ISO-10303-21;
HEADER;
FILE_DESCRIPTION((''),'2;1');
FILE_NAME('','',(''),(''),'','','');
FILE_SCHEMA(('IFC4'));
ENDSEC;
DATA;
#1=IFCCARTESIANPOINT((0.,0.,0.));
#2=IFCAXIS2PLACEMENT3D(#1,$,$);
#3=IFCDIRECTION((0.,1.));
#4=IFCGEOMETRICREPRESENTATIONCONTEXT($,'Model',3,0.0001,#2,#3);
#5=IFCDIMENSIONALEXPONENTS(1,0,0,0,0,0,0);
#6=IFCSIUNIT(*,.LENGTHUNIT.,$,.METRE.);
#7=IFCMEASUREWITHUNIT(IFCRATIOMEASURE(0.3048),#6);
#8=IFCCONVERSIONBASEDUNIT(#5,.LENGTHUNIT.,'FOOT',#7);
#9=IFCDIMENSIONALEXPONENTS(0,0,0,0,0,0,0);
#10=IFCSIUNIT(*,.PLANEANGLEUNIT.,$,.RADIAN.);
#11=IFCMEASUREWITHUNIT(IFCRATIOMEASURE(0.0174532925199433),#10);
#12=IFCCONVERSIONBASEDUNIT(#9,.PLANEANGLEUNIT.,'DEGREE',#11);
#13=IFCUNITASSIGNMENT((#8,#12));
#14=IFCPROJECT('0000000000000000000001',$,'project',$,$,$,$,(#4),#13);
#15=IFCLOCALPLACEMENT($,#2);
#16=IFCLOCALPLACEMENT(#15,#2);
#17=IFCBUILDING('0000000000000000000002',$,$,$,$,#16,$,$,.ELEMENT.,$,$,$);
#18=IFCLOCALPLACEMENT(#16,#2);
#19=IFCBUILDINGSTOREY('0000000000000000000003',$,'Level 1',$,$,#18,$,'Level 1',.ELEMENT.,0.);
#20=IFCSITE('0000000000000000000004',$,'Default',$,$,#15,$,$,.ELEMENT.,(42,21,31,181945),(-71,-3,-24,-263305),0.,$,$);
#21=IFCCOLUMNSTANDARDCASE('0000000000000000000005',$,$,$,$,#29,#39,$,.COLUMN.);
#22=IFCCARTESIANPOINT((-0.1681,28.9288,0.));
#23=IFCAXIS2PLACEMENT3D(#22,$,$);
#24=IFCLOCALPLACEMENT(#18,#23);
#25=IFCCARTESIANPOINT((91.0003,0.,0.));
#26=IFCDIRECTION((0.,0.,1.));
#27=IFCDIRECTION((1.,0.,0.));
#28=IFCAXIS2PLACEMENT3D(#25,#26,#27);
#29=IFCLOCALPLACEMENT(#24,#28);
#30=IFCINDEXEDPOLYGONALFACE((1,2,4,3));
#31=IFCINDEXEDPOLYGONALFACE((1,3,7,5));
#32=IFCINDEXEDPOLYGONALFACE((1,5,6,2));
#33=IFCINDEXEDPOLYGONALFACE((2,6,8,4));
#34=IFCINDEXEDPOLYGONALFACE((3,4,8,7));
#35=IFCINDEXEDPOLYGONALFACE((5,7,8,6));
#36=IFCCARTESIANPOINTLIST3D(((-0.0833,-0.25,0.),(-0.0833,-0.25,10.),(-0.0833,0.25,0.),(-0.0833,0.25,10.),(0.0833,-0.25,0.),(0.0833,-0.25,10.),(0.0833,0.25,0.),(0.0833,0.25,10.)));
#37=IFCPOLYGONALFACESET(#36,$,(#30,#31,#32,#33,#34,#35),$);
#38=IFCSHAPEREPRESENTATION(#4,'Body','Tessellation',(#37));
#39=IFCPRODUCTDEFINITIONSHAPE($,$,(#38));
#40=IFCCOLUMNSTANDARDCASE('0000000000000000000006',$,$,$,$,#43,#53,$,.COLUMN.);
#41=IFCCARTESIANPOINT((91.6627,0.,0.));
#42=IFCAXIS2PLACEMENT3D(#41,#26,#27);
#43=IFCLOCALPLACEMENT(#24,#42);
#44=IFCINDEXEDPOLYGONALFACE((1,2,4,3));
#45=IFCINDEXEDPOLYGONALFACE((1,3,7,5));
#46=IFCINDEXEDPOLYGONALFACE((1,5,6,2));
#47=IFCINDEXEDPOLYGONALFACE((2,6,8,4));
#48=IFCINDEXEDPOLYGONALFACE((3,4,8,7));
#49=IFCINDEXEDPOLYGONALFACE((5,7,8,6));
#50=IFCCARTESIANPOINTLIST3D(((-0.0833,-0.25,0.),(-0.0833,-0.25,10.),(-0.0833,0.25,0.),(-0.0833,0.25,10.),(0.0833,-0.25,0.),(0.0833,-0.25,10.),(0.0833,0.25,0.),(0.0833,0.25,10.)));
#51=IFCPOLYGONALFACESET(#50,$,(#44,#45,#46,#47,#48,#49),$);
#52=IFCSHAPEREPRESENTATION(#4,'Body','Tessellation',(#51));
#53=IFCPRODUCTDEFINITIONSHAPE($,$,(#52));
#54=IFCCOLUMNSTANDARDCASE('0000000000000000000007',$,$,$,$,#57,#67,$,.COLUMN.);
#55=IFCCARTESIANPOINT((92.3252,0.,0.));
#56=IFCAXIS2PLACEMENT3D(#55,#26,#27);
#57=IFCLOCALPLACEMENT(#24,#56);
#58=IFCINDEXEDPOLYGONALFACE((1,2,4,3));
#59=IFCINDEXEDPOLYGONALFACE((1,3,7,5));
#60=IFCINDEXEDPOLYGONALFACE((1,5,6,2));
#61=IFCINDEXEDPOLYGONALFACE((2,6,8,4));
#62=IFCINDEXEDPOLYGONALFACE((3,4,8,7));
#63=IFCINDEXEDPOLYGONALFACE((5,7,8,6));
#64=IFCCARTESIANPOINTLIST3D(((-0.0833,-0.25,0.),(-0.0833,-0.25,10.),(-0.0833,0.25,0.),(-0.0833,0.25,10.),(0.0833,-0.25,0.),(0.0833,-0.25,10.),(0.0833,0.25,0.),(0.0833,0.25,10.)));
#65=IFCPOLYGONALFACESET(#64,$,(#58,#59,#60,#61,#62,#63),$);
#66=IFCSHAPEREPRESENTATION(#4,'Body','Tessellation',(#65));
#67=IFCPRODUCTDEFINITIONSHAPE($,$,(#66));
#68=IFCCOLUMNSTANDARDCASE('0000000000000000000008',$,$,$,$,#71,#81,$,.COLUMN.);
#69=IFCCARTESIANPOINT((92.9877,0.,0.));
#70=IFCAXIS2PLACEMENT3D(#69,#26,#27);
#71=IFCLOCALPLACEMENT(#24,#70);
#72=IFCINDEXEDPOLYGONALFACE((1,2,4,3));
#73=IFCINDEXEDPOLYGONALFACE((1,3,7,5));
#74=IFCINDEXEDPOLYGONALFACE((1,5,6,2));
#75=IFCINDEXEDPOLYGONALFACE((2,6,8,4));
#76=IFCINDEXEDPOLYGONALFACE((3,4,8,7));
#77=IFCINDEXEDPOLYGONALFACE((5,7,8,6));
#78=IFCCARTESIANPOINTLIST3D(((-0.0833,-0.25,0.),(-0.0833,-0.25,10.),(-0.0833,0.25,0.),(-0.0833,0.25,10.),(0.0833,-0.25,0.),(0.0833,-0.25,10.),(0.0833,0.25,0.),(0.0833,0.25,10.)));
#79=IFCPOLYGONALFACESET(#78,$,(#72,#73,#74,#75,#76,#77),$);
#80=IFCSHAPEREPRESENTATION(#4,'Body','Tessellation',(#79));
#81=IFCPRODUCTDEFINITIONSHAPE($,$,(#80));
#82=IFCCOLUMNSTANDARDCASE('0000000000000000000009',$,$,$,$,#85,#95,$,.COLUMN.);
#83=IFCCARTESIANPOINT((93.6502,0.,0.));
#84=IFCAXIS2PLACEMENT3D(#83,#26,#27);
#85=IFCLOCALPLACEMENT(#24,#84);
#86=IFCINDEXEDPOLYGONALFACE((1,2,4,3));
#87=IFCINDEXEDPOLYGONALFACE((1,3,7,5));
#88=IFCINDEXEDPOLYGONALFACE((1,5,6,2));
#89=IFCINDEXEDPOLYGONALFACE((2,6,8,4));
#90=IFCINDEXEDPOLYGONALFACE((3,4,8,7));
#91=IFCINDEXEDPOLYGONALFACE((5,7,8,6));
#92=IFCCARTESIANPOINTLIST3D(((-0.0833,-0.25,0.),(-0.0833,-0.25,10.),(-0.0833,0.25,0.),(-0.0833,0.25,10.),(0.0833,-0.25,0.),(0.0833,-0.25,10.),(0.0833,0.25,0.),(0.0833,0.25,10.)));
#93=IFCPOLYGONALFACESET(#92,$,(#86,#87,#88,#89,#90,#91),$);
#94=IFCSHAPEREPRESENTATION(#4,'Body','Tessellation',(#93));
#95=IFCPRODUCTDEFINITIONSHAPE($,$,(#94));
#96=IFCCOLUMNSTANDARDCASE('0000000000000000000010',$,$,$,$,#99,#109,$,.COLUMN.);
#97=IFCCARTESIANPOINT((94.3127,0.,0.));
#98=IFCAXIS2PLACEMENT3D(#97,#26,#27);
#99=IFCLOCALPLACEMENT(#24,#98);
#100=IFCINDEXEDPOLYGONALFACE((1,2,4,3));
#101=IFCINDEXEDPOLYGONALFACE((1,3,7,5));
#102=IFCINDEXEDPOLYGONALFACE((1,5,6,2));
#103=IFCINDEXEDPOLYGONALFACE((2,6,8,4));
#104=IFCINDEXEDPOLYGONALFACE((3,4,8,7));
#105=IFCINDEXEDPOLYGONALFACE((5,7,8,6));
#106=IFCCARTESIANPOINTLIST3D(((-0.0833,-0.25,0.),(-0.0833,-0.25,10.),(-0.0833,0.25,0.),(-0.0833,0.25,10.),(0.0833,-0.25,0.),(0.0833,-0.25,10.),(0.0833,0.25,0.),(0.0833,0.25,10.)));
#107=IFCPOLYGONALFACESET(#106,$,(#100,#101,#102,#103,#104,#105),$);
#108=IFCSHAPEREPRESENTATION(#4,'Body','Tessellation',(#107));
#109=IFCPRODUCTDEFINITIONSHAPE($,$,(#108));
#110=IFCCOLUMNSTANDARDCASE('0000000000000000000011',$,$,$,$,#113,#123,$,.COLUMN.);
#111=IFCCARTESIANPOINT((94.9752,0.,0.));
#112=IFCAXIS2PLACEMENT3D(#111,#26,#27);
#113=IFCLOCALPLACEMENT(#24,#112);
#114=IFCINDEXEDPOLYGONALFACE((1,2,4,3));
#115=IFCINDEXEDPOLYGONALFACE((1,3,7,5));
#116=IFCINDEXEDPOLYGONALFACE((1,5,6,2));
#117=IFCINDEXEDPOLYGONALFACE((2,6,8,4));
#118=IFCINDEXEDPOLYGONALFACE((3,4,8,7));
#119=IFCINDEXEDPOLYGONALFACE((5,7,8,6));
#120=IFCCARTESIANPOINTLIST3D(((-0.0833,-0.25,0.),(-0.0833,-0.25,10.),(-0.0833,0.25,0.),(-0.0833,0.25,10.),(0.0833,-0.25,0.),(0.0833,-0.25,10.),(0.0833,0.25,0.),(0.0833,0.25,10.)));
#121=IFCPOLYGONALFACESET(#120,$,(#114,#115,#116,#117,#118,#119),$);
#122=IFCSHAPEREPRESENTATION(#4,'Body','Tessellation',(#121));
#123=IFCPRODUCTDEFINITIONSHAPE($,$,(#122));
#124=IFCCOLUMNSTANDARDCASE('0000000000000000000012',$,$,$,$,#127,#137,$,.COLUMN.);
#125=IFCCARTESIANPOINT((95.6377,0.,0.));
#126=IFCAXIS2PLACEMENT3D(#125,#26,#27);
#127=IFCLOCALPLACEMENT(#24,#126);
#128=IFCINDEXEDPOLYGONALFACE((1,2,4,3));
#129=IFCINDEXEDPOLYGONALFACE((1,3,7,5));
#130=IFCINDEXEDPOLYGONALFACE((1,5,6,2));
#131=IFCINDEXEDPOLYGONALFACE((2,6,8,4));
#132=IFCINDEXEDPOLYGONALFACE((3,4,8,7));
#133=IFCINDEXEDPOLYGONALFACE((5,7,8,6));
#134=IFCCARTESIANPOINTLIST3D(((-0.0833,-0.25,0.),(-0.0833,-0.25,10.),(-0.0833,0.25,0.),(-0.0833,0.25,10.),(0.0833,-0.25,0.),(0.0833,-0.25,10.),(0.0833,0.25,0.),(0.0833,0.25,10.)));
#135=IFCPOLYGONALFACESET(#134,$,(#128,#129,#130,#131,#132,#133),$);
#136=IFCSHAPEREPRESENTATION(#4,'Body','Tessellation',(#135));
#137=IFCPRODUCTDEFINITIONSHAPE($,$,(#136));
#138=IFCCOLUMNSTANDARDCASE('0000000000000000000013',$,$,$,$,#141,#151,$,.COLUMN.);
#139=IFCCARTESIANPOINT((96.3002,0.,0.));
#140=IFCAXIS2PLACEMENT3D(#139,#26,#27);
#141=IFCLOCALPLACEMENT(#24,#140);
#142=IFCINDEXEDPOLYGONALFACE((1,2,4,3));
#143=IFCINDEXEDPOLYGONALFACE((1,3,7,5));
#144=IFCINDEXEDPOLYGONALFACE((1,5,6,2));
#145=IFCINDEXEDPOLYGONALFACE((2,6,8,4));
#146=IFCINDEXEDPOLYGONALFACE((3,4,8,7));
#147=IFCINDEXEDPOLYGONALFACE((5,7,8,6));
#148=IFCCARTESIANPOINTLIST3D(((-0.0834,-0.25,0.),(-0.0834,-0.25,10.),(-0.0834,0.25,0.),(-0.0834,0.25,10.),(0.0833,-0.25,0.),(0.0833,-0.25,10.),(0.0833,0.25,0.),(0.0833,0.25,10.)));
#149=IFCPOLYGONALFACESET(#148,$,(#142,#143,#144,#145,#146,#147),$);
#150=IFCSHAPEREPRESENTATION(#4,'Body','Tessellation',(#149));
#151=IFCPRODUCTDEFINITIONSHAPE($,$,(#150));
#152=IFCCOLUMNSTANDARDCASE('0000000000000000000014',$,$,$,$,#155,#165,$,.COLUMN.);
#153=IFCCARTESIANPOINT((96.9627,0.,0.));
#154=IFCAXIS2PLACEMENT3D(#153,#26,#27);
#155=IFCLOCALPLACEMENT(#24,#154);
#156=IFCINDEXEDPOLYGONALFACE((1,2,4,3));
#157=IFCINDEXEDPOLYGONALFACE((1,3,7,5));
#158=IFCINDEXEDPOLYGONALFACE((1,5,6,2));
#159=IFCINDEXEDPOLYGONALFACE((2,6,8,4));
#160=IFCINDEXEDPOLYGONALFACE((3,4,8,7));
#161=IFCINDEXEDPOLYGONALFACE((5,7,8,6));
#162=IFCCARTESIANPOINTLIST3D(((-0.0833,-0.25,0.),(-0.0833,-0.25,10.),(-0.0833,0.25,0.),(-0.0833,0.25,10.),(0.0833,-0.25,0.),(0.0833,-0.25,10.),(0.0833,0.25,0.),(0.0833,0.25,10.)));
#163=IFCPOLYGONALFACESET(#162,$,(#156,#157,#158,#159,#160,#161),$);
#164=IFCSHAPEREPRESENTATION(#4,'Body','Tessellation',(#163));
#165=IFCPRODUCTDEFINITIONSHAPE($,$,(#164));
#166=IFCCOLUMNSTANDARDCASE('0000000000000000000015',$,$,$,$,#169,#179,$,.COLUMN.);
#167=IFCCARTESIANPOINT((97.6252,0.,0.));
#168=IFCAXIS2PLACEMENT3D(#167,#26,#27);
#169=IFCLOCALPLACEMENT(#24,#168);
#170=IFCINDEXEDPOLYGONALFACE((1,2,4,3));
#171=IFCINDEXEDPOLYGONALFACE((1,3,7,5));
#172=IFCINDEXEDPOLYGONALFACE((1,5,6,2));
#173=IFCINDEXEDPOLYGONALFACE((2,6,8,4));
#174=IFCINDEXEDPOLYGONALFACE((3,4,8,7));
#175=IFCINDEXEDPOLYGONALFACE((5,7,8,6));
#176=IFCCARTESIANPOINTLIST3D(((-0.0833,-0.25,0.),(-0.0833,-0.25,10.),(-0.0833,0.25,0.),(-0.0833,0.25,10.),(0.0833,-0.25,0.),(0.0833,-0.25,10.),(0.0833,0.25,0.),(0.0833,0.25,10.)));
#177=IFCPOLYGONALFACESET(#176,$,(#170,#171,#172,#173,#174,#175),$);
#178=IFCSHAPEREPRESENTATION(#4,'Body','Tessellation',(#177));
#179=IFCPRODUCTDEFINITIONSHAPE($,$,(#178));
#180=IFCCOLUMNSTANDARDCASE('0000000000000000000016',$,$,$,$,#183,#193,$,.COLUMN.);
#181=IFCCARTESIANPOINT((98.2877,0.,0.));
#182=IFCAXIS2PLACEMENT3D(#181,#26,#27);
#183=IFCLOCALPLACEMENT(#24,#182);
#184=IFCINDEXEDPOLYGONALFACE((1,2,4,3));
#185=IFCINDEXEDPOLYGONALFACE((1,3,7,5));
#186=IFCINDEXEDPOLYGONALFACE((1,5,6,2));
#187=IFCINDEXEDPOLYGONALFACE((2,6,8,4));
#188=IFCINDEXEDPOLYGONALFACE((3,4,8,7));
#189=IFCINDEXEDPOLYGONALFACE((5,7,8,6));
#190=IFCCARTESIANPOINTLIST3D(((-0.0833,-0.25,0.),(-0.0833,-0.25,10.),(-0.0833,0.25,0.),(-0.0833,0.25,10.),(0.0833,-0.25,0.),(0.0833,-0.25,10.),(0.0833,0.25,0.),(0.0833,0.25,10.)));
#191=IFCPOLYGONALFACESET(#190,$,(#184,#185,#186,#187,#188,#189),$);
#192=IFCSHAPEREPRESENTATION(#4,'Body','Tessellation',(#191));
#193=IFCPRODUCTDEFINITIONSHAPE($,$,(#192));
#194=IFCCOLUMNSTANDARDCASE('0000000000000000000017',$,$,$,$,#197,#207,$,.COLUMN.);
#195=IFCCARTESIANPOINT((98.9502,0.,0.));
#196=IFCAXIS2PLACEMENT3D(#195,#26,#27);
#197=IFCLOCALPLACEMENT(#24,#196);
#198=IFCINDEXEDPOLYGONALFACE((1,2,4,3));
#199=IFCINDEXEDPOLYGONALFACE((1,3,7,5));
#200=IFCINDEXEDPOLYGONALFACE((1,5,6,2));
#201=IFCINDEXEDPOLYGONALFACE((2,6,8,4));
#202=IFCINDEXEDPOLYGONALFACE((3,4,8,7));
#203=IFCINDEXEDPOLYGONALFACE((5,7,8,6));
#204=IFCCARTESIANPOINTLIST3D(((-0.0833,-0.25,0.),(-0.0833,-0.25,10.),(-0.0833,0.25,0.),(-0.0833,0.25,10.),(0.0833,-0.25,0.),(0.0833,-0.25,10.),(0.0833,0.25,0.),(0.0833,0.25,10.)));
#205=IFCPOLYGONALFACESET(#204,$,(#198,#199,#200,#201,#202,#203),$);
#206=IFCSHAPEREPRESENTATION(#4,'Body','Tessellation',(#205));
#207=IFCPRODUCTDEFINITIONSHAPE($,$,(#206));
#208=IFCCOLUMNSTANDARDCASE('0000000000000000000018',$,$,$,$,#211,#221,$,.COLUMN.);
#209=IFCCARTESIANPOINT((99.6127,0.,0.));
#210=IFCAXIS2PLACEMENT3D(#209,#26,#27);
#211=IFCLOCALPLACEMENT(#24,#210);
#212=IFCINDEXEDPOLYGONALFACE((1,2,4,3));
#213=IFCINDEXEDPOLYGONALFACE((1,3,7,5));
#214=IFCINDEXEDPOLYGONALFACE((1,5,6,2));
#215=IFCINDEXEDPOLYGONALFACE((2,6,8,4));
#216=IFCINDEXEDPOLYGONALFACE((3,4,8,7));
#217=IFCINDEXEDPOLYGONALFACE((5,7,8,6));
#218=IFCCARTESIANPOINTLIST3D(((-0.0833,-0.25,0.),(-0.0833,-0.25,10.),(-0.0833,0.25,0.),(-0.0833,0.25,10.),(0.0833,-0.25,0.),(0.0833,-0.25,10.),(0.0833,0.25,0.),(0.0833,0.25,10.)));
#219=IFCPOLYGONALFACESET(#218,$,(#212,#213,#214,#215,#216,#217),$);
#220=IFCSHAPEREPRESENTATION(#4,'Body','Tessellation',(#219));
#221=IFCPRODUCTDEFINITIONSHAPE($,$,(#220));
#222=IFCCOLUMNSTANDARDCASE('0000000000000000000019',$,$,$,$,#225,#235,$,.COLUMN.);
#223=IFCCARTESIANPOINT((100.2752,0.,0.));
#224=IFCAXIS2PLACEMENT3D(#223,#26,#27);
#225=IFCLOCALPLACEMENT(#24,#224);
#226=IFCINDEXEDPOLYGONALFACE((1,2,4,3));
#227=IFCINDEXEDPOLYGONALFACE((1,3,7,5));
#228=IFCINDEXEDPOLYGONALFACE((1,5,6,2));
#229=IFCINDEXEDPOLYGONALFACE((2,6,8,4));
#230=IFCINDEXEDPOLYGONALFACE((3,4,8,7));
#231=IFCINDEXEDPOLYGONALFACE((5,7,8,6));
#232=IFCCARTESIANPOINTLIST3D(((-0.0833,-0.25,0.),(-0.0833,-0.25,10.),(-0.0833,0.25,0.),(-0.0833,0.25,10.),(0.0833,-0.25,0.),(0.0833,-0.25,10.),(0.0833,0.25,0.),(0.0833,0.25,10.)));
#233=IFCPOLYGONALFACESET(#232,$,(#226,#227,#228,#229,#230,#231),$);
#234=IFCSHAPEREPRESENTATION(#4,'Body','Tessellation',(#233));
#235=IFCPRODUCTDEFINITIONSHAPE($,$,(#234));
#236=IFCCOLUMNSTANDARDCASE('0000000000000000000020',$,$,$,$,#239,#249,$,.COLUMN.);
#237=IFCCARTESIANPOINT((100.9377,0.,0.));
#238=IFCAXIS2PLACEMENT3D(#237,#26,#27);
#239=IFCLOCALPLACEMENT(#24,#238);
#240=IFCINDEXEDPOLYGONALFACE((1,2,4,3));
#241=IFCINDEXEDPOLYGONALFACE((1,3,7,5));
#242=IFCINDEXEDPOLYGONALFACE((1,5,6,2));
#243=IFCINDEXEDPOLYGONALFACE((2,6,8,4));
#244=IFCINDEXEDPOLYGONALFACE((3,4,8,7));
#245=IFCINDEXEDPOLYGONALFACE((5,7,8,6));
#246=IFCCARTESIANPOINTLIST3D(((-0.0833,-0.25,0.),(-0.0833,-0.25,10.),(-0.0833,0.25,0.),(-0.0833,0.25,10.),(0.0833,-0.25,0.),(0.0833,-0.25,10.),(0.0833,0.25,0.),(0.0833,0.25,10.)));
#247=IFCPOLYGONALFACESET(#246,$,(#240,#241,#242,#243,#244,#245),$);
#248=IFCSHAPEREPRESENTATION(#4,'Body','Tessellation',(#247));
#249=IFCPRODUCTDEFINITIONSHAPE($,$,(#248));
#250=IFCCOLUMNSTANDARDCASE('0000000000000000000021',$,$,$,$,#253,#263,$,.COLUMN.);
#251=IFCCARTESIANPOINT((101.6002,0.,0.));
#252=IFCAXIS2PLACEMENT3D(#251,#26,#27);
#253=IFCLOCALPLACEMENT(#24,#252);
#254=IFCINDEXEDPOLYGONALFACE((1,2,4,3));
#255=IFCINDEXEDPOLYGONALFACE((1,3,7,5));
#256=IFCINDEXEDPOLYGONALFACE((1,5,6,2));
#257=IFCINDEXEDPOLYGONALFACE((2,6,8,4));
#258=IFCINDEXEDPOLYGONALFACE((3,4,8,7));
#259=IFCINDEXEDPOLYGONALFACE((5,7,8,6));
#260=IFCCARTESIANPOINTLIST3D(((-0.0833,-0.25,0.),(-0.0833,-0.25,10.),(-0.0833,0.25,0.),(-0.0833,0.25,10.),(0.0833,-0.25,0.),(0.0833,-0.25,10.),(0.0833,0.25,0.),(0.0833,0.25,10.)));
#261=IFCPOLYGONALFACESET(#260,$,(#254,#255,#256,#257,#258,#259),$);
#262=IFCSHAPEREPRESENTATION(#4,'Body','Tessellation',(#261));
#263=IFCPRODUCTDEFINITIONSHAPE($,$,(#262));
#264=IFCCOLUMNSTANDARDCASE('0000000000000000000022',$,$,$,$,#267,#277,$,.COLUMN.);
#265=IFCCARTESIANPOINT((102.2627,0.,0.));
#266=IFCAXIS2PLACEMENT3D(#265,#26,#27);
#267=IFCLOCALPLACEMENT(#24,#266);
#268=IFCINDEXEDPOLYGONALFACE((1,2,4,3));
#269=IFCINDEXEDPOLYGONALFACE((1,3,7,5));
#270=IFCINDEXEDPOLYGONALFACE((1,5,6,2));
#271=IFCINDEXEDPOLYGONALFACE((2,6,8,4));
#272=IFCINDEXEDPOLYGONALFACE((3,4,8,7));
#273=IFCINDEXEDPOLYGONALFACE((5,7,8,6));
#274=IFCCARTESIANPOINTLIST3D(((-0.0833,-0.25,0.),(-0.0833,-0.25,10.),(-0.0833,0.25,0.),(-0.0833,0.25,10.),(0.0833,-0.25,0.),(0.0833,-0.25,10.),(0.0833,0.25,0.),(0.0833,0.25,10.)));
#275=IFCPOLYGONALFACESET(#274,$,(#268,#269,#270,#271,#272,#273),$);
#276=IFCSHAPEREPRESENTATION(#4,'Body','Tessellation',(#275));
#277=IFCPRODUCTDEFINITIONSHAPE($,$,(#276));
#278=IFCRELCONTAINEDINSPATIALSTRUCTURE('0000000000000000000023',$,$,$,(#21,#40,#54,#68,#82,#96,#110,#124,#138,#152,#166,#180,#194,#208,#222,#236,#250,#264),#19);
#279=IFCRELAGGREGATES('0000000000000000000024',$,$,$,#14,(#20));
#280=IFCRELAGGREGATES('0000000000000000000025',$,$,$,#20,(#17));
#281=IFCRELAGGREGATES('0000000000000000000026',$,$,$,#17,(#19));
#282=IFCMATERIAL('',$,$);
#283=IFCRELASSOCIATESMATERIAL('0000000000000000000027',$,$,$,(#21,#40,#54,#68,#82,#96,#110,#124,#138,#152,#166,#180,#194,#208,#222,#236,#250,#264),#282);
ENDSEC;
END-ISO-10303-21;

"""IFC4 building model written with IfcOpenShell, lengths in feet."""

from ifc_helpers import new_model, entity, si_unit, converted_unit, direction, frame, origin, place, context, project, spatial, rectangle, extrude, material, element, save


model = new_model("IFC4")

# Units and contexts
model_context = context("Model", 3, precision=0.0001, world=origin(), true_north=direction((0.0, 1.0)))
ifc_project = project(units=[converted_unit("LENGTHUNIT", "FOOT", entity("IfcRatioMeasure", 0.3048), si_unit("LENGTHUNIT", "METRE"), dimensions=[1, 0, 0, 0, 0, 0, 0]), converted_unit("PLANEANGLEUNIT", "DEGREE", entity("IfcRatioMeasure", 0.0174532925199433), si_unit("PLANEANGLEUNIT", "RADIAN"), dimensions=[0, 0, 0, 0, 0, 0, 0])], contexts=[model_context])

# Site, building, storey
site_placement = place(None, origin())
site = spatial("IfcSite", under=ifc_project, at=site_placement, Name="Default", CompositionType="ELEMENT", RefLatitude=(42, 21, 31, 181945), RefLongitude=(-71, -3, -24, -263305), RefElevation=0.0)
building_placement = place(site_placement, origin())
building = spatial("IfcBuilding", under=site, at=building_placement, CompositionType="ELEMENT")
storey_placement = place(building_placement, origin())
storey = spatial("IfcBuildingStorey", under=building, at=storey_placement, Name="Level 1", LongName="Level 1", CompositionType="ELEMENT", Elevation=0.0)

# Columns
ifc_material_1 = material(Name="")
placement_1 = place(storey_placement, frame((-0.1681, 28.9288, 0.0)))
for number, where, z_axis, x_axis in (
    (1, (91.0003, 0.0, 0.0), (0.0, 0.0, 1.0), (1.0, 0.0, 0.0)),
    (2, (91.6627, 0.0, 0.0), (0.0, 0.0, 1.0), (1.0, 0.0, 0.0)),
    (3, (92.3252, 0.0, 0.0), (0.0, 0.0, 1.0), (1.0, 0.0, 0.0)),
    (4, (92.9877, 0.0, 0.0), (0.0, 0.0, 1.0), (1.0, 0.0, 0.0)),
    (5, (93.6502, 0.0, 0.0), (0.0, 0.0, 1.0), (1.0, 0.0, 0.0)),
    (6, (94.3127, 0.0, 0.0), (0.0, 0.0, 1.0), (1.0, 0.0, 0.0)),
    (7, (94.9752, 0.0, 0.0), (0.0, 0.0, 1.0), (1.0, 0.0, 0.0)),
    (8, (95.6377, 0.0, 0.0), (0.0, 0.0, 1.0), (1.0, 0.0, 0.0)),
    (9, (96.3002, 0.0, 0.0), (0.0, 0.0, 1.0), (1.0, 0.0, 0.0)),
    (10, (96.9627, 0.0, 0.0), (0.0, 0.0, 1.0), (1.0, 0.0, 0.0)),
    (11, (97.6252, 0.0, 0.0), (0.0, 0.0, 1.0), (1.0, 0.0, 0.0)),
    (12, (98.2877, 0.0, 0.0), (0.0, 0.0, 1.0), (1.0, 0.0, 0.0)),
    (13, (98.9502, 0.0, 0.0), (0.0, 0.0, 1.0), (1.0, 0.0, 0.0)),
    (14, (99.6127, 0.0, 0.0), (0.0, 0.0, 1.0), (1.0, 0.0, 0.0)),
    (15, (100.2752, 0.0, 0.0), (0.0, 0.0, 1.0), (1.0, 0.0, 0.0)),
    (16, (100.9377, 0.0, 0.0), (0.0, 0.0, 1.0), (1.0, 0.0, 0.0)),
    (17, (101.6002, 0.0, 0.0), (0.0, 0.0, 1.0), (1.0, 0.0, 0.0)),
    (18, (102.2627, 0.0, 0.0), (0.0, 0.0, 1.0), (1.0, 0.0, 0.0)),
):
    element("IfcColumnStandardCase", number, at=place(placement_1, frame(where, z_axis=z_axis, x_axis=x_axis)), inside=storey, material=ifc_material_1, PredefinedType="COLUMN", context=model_context, shape_type="SweptSolid", body=[
        extrude(rectangle(XDim=0.1667, YDim=0.5), origin(), (0.0, 0.0, 1.0), 10.0),
    ])

save(model, "model.ifc")
